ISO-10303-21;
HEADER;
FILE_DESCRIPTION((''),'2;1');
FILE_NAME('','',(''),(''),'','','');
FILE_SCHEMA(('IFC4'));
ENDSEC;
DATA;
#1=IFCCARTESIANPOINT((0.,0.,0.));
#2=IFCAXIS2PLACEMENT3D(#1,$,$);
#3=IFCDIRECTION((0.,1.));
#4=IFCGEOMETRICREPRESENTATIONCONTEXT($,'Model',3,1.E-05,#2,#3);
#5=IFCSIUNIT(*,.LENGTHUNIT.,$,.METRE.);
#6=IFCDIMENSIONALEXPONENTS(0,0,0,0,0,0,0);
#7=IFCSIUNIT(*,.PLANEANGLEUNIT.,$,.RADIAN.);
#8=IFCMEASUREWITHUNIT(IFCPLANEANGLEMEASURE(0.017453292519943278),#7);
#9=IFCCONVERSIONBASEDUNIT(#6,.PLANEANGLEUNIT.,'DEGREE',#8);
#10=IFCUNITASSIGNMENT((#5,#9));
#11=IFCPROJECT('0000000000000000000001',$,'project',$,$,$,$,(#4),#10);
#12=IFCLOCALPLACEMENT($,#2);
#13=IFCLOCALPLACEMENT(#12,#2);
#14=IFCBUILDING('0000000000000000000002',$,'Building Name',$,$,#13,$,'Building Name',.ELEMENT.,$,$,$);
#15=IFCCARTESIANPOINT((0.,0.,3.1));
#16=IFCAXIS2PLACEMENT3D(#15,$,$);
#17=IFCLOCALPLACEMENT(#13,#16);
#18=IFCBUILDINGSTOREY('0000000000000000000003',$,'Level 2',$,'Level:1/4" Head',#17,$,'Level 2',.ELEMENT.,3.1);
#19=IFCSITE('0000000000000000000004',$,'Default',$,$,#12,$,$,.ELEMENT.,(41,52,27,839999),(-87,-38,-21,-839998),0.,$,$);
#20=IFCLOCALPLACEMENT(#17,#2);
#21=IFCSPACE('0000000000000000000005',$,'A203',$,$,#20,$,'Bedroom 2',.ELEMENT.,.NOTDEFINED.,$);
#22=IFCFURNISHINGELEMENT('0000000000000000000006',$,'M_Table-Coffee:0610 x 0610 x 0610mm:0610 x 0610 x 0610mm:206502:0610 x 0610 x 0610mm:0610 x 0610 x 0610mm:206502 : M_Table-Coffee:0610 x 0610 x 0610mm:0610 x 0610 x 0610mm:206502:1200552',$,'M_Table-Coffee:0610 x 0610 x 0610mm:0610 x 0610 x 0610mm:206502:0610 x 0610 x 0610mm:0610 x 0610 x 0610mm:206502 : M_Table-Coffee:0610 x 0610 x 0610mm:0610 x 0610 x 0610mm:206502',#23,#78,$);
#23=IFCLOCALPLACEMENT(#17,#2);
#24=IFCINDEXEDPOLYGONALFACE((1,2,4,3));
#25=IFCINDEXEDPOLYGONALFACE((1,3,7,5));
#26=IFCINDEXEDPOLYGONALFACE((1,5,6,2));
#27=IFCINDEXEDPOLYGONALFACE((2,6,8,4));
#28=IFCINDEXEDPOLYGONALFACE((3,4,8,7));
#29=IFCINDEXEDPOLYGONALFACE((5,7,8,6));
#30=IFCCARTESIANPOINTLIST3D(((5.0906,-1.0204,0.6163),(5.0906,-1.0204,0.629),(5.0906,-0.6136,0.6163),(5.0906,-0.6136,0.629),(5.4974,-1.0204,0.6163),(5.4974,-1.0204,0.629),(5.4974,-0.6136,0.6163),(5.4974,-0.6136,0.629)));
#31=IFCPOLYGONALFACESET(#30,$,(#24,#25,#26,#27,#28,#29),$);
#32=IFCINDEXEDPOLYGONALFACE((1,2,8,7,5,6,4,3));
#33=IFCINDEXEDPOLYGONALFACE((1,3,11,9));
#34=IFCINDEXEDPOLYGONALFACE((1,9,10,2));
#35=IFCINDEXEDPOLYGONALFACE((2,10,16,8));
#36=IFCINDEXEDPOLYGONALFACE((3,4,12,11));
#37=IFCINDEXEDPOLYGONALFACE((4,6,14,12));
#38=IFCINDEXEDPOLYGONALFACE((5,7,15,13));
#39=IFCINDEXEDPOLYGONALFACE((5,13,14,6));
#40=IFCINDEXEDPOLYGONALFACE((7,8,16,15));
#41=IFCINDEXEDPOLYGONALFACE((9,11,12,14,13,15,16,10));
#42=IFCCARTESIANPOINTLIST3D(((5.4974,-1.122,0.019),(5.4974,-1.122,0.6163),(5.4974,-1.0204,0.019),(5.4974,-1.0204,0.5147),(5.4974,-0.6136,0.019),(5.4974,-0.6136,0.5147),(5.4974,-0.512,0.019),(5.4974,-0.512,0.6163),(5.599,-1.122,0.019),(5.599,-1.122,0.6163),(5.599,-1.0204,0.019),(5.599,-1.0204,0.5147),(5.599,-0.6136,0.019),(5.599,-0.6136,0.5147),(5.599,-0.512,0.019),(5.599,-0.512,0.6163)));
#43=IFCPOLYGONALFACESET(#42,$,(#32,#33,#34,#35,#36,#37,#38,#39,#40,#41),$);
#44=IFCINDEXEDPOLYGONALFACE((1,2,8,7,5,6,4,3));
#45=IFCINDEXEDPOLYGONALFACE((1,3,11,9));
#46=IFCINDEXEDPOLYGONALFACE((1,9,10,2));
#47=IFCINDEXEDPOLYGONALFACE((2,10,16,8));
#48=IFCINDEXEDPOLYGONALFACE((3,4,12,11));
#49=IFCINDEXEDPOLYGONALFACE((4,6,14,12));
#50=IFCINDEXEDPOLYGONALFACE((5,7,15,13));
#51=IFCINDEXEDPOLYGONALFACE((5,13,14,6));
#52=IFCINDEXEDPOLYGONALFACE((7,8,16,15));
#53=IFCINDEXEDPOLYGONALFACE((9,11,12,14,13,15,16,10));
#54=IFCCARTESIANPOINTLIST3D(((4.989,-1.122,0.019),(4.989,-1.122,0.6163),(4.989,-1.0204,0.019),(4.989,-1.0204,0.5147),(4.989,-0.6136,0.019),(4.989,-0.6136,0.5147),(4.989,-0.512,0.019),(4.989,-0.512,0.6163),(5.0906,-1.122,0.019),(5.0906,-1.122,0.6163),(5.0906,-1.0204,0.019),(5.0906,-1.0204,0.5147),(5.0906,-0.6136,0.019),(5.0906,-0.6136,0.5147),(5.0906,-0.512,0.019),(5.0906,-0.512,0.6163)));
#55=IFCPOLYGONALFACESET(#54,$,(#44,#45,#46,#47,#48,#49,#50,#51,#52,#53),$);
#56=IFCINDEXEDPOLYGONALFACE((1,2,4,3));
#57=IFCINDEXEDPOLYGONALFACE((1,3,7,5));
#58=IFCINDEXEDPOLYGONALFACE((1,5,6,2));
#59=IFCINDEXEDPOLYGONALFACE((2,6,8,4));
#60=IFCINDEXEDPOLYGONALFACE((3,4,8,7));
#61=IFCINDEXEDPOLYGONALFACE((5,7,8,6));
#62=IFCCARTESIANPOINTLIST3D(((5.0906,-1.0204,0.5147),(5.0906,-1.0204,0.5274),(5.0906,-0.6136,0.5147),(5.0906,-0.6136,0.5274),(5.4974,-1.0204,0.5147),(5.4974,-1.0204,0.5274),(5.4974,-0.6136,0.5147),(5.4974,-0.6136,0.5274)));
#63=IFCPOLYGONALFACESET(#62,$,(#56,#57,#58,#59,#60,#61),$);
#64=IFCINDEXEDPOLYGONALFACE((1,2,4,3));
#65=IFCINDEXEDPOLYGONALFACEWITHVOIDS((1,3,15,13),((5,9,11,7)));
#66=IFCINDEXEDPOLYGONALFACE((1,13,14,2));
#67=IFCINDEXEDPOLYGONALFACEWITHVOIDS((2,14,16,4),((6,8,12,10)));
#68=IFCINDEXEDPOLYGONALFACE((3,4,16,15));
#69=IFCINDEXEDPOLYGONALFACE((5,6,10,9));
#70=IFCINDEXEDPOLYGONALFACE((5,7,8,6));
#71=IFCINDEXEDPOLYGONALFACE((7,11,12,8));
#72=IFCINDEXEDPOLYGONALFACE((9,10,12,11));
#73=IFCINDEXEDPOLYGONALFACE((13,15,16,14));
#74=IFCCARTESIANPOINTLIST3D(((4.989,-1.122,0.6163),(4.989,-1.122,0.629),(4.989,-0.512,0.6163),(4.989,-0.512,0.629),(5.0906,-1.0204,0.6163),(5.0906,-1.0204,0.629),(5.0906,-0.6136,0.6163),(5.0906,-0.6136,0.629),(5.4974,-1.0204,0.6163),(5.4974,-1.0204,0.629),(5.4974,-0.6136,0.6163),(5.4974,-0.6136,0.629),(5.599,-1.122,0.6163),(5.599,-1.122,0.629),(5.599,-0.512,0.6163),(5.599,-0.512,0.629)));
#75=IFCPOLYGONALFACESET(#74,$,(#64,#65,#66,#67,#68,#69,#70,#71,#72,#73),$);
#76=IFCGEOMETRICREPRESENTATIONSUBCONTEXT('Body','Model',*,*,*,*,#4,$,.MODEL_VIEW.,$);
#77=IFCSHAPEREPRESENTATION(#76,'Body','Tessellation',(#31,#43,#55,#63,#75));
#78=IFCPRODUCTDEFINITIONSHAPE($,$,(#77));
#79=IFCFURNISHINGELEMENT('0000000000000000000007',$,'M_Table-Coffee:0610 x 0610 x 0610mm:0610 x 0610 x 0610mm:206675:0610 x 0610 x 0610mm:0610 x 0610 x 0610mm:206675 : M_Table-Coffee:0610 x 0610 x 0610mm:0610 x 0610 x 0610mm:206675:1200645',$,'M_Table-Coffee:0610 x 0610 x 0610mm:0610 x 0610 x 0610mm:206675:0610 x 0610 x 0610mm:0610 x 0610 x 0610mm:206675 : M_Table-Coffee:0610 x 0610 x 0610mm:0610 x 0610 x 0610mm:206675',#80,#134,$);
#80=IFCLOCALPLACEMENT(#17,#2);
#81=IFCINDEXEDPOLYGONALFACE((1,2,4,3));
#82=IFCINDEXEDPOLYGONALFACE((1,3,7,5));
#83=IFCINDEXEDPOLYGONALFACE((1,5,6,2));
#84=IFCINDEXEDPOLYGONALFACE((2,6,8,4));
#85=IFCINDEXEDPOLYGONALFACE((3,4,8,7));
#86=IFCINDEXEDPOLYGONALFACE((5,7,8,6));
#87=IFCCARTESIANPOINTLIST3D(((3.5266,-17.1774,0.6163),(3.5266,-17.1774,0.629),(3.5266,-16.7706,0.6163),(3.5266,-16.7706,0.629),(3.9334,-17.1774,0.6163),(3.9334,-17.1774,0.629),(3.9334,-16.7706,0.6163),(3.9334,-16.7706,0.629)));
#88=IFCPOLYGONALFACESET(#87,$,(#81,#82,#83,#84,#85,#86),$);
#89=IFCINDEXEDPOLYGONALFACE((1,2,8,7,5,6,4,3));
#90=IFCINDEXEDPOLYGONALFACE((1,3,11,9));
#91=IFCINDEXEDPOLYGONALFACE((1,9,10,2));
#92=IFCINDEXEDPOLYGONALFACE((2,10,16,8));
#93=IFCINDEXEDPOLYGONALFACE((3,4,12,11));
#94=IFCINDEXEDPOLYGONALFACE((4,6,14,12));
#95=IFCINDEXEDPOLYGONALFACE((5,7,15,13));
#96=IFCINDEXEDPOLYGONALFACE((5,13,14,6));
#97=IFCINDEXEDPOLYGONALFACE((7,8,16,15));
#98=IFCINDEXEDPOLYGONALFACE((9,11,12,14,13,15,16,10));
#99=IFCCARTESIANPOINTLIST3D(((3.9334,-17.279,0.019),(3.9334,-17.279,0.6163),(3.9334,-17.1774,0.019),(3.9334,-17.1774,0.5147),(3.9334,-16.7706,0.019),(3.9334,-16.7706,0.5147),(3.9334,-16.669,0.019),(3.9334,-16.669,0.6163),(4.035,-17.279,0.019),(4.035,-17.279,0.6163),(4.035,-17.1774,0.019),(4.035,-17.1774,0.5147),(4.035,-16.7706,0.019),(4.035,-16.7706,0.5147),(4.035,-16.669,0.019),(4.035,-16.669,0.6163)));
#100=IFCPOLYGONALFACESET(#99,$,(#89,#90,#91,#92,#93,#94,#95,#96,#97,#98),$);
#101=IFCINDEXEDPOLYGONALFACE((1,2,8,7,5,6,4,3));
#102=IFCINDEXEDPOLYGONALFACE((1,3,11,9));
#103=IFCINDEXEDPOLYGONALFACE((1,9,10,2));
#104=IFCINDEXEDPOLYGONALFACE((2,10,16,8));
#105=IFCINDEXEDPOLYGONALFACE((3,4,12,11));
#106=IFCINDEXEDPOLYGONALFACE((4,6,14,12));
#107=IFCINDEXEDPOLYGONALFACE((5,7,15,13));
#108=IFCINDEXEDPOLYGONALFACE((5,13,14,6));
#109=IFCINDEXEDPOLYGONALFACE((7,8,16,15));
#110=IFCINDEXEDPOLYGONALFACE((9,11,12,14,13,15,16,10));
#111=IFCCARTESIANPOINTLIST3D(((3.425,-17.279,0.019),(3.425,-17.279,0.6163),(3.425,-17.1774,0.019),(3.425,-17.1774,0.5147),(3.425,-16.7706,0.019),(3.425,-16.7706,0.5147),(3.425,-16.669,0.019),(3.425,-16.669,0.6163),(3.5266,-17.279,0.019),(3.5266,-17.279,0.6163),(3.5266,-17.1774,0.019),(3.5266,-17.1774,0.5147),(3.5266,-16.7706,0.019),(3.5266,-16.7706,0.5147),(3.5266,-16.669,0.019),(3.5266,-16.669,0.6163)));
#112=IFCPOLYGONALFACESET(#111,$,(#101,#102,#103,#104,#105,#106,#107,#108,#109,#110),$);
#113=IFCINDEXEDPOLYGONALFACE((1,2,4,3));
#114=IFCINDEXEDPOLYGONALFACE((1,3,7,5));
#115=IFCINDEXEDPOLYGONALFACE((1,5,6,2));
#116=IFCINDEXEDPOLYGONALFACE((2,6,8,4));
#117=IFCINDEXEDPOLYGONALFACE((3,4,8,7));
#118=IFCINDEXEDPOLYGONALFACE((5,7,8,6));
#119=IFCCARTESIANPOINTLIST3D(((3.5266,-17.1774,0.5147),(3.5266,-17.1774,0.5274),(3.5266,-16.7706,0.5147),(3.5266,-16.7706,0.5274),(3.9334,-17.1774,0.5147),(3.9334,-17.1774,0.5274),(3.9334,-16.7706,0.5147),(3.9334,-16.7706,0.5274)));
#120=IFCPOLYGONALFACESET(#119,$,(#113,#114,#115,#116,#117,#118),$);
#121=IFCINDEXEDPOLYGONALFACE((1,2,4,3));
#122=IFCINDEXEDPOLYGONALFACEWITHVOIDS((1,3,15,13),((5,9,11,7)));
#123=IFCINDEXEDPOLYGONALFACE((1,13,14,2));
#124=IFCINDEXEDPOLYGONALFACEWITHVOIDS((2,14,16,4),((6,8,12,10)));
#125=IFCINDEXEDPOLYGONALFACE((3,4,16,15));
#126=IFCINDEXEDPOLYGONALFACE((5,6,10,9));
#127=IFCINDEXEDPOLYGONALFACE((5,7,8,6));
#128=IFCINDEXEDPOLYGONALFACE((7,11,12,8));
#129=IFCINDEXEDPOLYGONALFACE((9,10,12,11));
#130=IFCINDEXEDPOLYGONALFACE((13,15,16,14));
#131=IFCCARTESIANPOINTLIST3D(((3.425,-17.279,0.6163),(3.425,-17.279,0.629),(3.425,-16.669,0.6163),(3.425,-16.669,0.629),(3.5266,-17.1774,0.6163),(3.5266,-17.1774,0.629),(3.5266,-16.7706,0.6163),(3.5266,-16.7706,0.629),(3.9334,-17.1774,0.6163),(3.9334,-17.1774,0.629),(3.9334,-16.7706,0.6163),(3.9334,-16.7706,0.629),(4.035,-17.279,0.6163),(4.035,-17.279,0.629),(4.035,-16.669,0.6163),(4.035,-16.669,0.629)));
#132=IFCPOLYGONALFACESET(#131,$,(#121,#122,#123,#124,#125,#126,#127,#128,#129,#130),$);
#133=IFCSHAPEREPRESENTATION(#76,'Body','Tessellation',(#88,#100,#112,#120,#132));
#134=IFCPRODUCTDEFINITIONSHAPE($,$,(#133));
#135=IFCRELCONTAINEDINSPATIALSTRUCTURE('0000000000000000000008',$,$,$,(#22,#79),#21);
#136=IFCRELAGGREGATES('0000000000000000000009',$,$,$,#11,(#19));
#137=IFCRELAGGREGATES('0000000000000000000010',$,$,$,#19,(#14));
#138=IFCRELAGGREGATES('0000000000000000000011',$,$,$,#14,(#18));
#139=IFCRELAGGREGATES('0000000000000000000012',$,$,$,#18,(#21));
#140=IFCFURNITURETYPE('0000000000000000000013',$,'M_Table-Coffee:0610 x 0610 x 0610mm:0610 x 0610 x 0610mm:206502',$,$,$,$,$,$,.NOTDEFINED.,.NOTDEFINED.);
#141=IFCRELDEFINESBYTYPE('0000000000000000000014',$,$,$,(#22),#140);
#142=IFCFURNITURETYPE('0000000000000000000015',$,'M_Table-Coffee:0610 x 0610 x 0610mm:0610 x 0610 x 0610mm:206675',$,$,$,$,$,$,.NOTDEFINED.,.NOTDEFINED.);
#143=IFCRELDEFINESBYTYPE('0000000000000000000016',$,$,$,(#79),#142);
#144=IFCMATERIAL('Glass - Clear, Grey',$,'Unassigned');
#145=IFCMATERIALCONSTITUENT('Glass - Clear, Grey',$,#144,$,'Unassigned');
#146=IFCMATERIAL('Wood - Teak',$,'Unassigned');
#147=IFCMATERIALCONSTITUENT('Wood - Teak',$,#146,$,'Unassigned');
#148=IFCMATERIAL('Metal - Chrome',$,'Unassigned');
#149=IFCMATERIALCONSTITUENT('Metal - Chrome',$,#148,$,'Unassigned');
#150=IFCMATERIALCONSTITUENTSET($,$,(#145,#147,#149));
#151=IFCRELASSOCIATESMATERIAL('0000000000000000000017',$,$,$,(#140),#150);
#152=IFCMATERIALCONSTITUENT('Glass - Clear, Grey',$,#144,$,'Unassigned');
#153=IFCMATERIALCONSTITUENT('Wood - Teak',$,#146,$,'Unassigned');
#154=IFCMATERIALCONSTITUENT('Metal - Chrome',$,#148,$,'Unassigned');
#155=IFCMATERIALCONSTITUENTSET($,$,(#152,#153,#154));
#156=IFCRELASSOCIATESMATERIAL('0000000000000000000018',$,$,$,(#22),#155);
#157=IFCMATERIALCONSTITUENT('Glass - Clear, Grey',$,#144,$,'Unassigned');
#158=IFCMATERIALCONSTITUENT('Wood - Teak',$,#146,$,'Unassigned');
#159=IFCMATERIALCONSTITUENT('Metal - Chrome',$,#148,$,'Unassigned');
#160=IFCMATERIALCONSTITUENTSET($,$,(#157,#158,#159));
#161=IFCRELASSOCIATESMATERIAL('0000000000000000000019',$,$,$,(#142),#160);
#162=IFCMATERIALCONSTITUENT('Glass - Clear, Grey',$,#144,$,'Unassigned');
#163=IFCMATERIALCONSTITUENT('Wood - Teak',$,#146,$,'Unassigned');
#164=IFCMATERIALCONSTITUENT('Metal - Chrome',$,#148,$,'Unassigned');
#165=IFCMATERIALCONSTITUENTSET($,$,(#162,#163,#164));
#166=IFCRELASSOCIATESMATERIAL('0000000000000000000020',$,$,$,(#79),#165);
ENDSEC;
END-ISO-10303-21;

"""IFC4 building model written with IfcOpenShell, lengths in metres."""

from ifc_helpers import new_model, entity, si_unit, converted_unit, direction, frame, origin, place, context, subcontext, project, spatial, indexed_curve, outline, extrude, source, transform, mapped, material, constituent, constituent_set, type_object, type_shapes, element, save


model = new_model("IFC4")

# Units and contexts
model_context = context("Model", 3, precision=1e-05, world=origin(), true_north=direction((0.0, 1.0)))
body_context = subcontext(model_context, "Body", "Model", "MODEL_VIEW")
ifc_project = project(units=[si_unit("LENGTHUNIT", "METRE"), converted_unit("PLANEANGLEUNIT", "DEGREE", entity("IfcPlaneAngleMeasure", 0.017453292519943278), si_unit("PLANEANGLEUNIT", "RADIAN"), dimensions=[0, 0, 0, 0, 0, 0, 0])], contexts=[model_context])

# Site, building, storey
site_placement = place(None, origin())
site = spatial("IfcSite", under=ifc_project, at=site_placement, Name="Default", CompositionType="ELEMENT", RefLatitude=(41, 52, 27, 839999), RefLongitude=(-87, -38, -21, -839998), RefElevation=0.0)
building_placement = place(site_placement, origin())
building = spatial("IfcBuilding", under=site, at=building_placement, Name="Building Name", LongName="Building Name", CompositionType="ELEMENT")
storey_placement = place(building_placement, frame((0.0, 0.0, 3.1)))
storey = spatial("IfcBuildingStorey", under=building, at=storey_placement, Name="Level 2", ObjectType="Level:1/4\" Head", LongName="Level 2", CompositionType="ELEMENT", Elevation=3.1)

# Shared definitions
space_placement = place(storey_placement, origin())
space = spatial("IfcSpace", under=storey, at=space_placement, Name="A203", LongName="Bedroom 2", CompositionType="ELEMENT", PredefinedType="NOTDEFINED")

# Furnishing elements
ifc_material_1 = material(Name="Glass - Clear, Grey", Category="Unassigned")
ifc_material_2 = material(Name="Wood - Teak", Category="Unassigned")
ifc_material_3 = material(Name="Metal - Chrome", Category="Unassigned")
ifc_constituent_1 = constituent(ifc_material_1, Name="Glass - Clear, Grey", Category="Unassigned")
ifc_constituent_2 = constituent(ifc_material_2, Name="Wood - Teak", Category="Unassigned")
ifc_constituent_3 = constituent(ifc_material_3, Name="Metal - Chrome", Category="Unassigned")
ifc_constituent_set_1 = constituent_set(constituents=[ifc_constituent_1, ifc_constituent_2, ifc_constituent_3])
ifc_constituent_4 = constituent(ifc_material_1, Name="Glass - Clear, Grey", Category="Unassigned")
ifc_constituent_5 = constituent(ifc_material_2, Name="Wood - Teak", Category="Unassigned")
ifc_constituent_6 = constituent(ifc_material_3, Name="Metal - Chrome", Category="Unassigned")
ifc_constituent_set_2 = constituent_set(constituents=[ifc_constituent_4, ifc_constituent_5, ifc_constituent_6])
furniture_type_1 = type_object("IfcFurnitureType", Name="M_Table-Coffee:0610 x 0610 x 0610mm:0610 x 0610 x 0610mm:206502", AssemblyPlace="NOTDEFINED", PredefinedType="NOTDEFINED", material=ifc_constituent_set_2)
shared_shape_1 = source(origin(), body_context, "Body", "SweptSolid", [
    extrude(outline(indexed_curve([(-0.2034, -0.2034), (0.2034, -0.2034), (0.2034, 0.2034), (-0.2034, 0.2034), (-0.2034, -0.2034)], self_intersect=False)), frame((5.294, -0.817, 3.7163), z_axis=(0.0, 0.0, 1.0), x_axis=(0.0, -1.0, 0.0)), (0.0, 0.0, 1.0), 0.0127),
    extrude(outline(indexed_curve([(-0.305, -0.324), (0.305, -0.324), (0.305, 0.2732), (0.2034, 0.2732), (0.2034, -0.2225), (-0.2034, -0.2225), (-0.2034, 0.2732), (-0.305, 0.2732), (-0.305, -0.324)], self_intersect=False)), frame((5.4974, -0.817, 3.3923), z_axis=(1.0, 0.0, 0.0), x_axis=(0.0, -1.0, 0.0)), (0.0, 0.0, 1.0), 0.1016),
    extrude(outline(indexed_curve([(-0.3241, -0.305), (0.2733, -0.305), (0.2733, -0.2034), (-0.2224, -0.2034), (-0.2224, 0.2034), (0.2733, 0.2034), (0.2733, 0.305), (-0.3241, 0.305), (-0.3241, -0.305)], self_intersect=False)), frame((4.989, -0.817, 3.3923), z_axis=(1.0, 0.0, 0.0), x_axis=(0.0, 0.0, -1.0)), (0.0, 0.0, 1.0), 0.1016),
    extrude(outline(indexed_curve([(-0.2034, -0.2034), (0.2034, -0.2034), (0.2034, 0.2034), (-0.2034, 0.2034), (-0.2034, -0.2034)], self_intersect=False)), frame((5.294, -0.817, 3.6147), z_axis=(0.0, 0.0, 1.0), x_axis=(0.0, -1.0, 0.0)), (0.0, 0.0, 1.0), 0.0127),
    extrude(outline(indexed_curve([(-0.305, -0.305), (0.305, -0.305), (0.305, 0.305), (-0.305, 0.305), (-0.305, -0.305)], self_intersect=False), holes=[indexed_curve([(0.2034, 0.2034), (0.2034, -0.2034), (-0.2034, -0.2034), (-0.2034, 0.2034), (0.2034, 0.2034)], self_intersect=False)]), frame((5.294, -0.817, 3.7163), z_axis=(0.0, 0.0, 1.0), x_axis=(0.0, -1.0, 0.0)), (0.0, 0.0, 1.0), 0.0127),
])
type_shapes(furniture_type_1, [shared_shape_1])
furnishing_1_placement = place(space_placement, frame((0.0, 0.0, -3.1)))
element("IfcFurnishingElement", 1, at=furnishing_1_placement, inside=space, type_object=furniture_type_1, material=ifc_constituent_set_1, Name="M_Table-Coffee:0610 x 0610 x 0610mm:0610 x 0610 x 0610mm:206502:0610 x 0610 x 0610mm:0610 x 0610 x 0610mm:206502 : M_Table-Coffee:0610 x 0610 x 0610mm:0610 x 0610 x 0610mm:206502:1200552", ObjectType="M_Table-Coffee:0610 x 0610 x 0610mm:0610 x 0610 x 0610mm:206502:0610 x 0610 x 0610mm:0610 x 0610 x 0610mm:206502 : M_Table-Coffee:0610 x 0610 x 0610mm:0610 x 0610 x 0610mm:206502", context=body_context, shape_type="MappedRepresentation", body=[
    mapped(shared_shape_1, transform((0.0, 0.0, 0.0), scale=1.0)),
])
ifc_constituent_7 = constituent(ifc_material_1, Name="Glass - Clear, Grey", Category="Unassigned")
ifc_constituent_8 = constituent(ifc_material_2, Name="Wood - Teak", Category="Unassigned")
ifc_constituent_9 = constituent(ifc_material_3, Name="Metal - Chrome", Category="Unassigned")
ifc_constituent_set_3 = constituent_set(constituents=[ifc_constituent_7, ifc_constituent_8, ifc_constituent_9])
ifc_constituent_10 = constituent(ifc_material_1, Name="Glass - Clear, Grey", Category="Unassigned")
ifc_constituent_11 = constituent(ifc_material_2, Name="Wood - Teak", Category="Unassigned")
ifc_constituent_12 = constituent(ifc_material_3, Name="Metal - Chrome", Category="Unassigned")
ifc_constituent_set_4 = constituent_set(constituents=[ifc_constituent_10, ifc_constituent_11, ifc_constituent_12])
furniture_type_2 = type_object("IfcFurnitureType", Name="M_Table-Coffee:0610 x 0610 x 0610mm:0610 x 0610 x 0610mm:206675", AssemblyPlace="NOTDEFINED", PredefinedType="NOTDEFINED", material=ifc_constituent_set_4)
shared_shape_2 = source(origin(), body_context, "Body", "SweptSolid", [
    extrude(outline(indexed_curve([(-0.2034, -0.2034), (0.2034, -0.2034), (0.2034, 0.2034), (-0.2034, 0.2034), (-0.2034, -0.2034)], self_intersect=False)), frame((3.73, -16.974, 3.7163), z_axis=(0.0, 0.0, 1.0), x_axis=(0.0, -1.0, 0.0)), (0.0, 0.0, 1.0), 0.0127),
    extrude(outline(indexed_curve([(-0.305, -0.324), (0.305, -0.324), (0.305, 0.2732), (0.2034, 0.2732), (0.2034, -0.2225), (-0.2034, -0.2225), (-0.2034, 0.2732), (-0.305, 0.2732), (-0.305, -0.324)], self_intersect=False)), frame((3.9334, -16.974, 3.3923), z_axis=(1.0, 0.0, 0.0), x_axis=(0.0, -1.0, 0.0)), (0.0, 0.0, 1.0), 0.1016),
    extrude(outline(indexed_curve([(-0.3241, -0.305), (0.2733, -0.305), (0.2733, -0.2034), (-0.2224, -0.2034), (-0.2224, 0.2034), (0.2733, 0.2034), (0.2733, 0.305), (-0.3241, 0.305), (-0.3241, -0.305)], self_intersect=False)), frame((3.425, -16.974, 3.3923), z_axis=(1.0, 0.0, 0.0), x_axis=(0.0, 0.0, -1.0)), (0.0, 0.0, 1.0), 0.1016),
    extrude(outline(indexed_curve([(-0.2034, -0.2034), (0.2034, -0.2034), (0.2034, 0.2034), (-0.2034, 0.2034), (-0.2034, -0.2034)], self_intersect=False)), frame((3.73, -16.974, 3.6147), z_axis=(0.0, 0.0, 1.0), x_axis=(0.0, -1.0, 0.0)), (0.0, 0.0, 1.0), 0.0127),
    extrude(outline(indexed_curve([(-0.305, -0.305), (0.305, -0.305), (0.305, 0.305), (-0.305, 0.305), (-0.305, -0.305)], self_intersect=False), holes=[indexed_curve([(0.2034, 0.2034), (0.2034, -0.2034), (-0.2034, -0.2034), (-0.2034, 0.2034), (0.2034, 0.2034)], self_intersect=False)]), frame((3.73, -16.974, 3.7163), z_axis=(0.0, 0.0, 1.0), x_axis=(0.0, -1.0, 0.0)), (0.0, 0.0, 1.0), 0.0127),
])
type_shapes(furniture_type_2, [shared_shape_2])
furnishing_2_placement = place(space_placement, frame((0.0, 0.0, -3.1)))
element("IfcFurnishingElement", 2, at=furnishing_2_placement, inside=space, type_object=furniture_type_2, material=ifc_constituent_set_3, Name="M_Table-Coffee:0610 x 0610 x 0610mm:0610 x 0610 x 0610mm:206675:0610 x 0610 x 0610mm:0610 x 0610 x 0610mm:206675 : M_Table-Coffee:0610 x 0610 x 0610mm:0610 x 0610 x 0610mm:206675:1200645", ObjectType="M_Table-Coffee:0610 x 0610 x 0610mm:0610 x 0610 x 0610mm:206675:0610 x 0610 x 0610mm:0610 x 0610 x 0610mm:206675 : M_Table-Coffee:0610 x 0610 x 0610mm:0610 x 0610 x 0610mm:206675", context=body_context, shape_type="MappedRepresentation", body=[
    mapped(shared_shape_2, transform((0.0, 0.0, 0.0), scale=1.0)),
])

save(model, "model.ifc")
